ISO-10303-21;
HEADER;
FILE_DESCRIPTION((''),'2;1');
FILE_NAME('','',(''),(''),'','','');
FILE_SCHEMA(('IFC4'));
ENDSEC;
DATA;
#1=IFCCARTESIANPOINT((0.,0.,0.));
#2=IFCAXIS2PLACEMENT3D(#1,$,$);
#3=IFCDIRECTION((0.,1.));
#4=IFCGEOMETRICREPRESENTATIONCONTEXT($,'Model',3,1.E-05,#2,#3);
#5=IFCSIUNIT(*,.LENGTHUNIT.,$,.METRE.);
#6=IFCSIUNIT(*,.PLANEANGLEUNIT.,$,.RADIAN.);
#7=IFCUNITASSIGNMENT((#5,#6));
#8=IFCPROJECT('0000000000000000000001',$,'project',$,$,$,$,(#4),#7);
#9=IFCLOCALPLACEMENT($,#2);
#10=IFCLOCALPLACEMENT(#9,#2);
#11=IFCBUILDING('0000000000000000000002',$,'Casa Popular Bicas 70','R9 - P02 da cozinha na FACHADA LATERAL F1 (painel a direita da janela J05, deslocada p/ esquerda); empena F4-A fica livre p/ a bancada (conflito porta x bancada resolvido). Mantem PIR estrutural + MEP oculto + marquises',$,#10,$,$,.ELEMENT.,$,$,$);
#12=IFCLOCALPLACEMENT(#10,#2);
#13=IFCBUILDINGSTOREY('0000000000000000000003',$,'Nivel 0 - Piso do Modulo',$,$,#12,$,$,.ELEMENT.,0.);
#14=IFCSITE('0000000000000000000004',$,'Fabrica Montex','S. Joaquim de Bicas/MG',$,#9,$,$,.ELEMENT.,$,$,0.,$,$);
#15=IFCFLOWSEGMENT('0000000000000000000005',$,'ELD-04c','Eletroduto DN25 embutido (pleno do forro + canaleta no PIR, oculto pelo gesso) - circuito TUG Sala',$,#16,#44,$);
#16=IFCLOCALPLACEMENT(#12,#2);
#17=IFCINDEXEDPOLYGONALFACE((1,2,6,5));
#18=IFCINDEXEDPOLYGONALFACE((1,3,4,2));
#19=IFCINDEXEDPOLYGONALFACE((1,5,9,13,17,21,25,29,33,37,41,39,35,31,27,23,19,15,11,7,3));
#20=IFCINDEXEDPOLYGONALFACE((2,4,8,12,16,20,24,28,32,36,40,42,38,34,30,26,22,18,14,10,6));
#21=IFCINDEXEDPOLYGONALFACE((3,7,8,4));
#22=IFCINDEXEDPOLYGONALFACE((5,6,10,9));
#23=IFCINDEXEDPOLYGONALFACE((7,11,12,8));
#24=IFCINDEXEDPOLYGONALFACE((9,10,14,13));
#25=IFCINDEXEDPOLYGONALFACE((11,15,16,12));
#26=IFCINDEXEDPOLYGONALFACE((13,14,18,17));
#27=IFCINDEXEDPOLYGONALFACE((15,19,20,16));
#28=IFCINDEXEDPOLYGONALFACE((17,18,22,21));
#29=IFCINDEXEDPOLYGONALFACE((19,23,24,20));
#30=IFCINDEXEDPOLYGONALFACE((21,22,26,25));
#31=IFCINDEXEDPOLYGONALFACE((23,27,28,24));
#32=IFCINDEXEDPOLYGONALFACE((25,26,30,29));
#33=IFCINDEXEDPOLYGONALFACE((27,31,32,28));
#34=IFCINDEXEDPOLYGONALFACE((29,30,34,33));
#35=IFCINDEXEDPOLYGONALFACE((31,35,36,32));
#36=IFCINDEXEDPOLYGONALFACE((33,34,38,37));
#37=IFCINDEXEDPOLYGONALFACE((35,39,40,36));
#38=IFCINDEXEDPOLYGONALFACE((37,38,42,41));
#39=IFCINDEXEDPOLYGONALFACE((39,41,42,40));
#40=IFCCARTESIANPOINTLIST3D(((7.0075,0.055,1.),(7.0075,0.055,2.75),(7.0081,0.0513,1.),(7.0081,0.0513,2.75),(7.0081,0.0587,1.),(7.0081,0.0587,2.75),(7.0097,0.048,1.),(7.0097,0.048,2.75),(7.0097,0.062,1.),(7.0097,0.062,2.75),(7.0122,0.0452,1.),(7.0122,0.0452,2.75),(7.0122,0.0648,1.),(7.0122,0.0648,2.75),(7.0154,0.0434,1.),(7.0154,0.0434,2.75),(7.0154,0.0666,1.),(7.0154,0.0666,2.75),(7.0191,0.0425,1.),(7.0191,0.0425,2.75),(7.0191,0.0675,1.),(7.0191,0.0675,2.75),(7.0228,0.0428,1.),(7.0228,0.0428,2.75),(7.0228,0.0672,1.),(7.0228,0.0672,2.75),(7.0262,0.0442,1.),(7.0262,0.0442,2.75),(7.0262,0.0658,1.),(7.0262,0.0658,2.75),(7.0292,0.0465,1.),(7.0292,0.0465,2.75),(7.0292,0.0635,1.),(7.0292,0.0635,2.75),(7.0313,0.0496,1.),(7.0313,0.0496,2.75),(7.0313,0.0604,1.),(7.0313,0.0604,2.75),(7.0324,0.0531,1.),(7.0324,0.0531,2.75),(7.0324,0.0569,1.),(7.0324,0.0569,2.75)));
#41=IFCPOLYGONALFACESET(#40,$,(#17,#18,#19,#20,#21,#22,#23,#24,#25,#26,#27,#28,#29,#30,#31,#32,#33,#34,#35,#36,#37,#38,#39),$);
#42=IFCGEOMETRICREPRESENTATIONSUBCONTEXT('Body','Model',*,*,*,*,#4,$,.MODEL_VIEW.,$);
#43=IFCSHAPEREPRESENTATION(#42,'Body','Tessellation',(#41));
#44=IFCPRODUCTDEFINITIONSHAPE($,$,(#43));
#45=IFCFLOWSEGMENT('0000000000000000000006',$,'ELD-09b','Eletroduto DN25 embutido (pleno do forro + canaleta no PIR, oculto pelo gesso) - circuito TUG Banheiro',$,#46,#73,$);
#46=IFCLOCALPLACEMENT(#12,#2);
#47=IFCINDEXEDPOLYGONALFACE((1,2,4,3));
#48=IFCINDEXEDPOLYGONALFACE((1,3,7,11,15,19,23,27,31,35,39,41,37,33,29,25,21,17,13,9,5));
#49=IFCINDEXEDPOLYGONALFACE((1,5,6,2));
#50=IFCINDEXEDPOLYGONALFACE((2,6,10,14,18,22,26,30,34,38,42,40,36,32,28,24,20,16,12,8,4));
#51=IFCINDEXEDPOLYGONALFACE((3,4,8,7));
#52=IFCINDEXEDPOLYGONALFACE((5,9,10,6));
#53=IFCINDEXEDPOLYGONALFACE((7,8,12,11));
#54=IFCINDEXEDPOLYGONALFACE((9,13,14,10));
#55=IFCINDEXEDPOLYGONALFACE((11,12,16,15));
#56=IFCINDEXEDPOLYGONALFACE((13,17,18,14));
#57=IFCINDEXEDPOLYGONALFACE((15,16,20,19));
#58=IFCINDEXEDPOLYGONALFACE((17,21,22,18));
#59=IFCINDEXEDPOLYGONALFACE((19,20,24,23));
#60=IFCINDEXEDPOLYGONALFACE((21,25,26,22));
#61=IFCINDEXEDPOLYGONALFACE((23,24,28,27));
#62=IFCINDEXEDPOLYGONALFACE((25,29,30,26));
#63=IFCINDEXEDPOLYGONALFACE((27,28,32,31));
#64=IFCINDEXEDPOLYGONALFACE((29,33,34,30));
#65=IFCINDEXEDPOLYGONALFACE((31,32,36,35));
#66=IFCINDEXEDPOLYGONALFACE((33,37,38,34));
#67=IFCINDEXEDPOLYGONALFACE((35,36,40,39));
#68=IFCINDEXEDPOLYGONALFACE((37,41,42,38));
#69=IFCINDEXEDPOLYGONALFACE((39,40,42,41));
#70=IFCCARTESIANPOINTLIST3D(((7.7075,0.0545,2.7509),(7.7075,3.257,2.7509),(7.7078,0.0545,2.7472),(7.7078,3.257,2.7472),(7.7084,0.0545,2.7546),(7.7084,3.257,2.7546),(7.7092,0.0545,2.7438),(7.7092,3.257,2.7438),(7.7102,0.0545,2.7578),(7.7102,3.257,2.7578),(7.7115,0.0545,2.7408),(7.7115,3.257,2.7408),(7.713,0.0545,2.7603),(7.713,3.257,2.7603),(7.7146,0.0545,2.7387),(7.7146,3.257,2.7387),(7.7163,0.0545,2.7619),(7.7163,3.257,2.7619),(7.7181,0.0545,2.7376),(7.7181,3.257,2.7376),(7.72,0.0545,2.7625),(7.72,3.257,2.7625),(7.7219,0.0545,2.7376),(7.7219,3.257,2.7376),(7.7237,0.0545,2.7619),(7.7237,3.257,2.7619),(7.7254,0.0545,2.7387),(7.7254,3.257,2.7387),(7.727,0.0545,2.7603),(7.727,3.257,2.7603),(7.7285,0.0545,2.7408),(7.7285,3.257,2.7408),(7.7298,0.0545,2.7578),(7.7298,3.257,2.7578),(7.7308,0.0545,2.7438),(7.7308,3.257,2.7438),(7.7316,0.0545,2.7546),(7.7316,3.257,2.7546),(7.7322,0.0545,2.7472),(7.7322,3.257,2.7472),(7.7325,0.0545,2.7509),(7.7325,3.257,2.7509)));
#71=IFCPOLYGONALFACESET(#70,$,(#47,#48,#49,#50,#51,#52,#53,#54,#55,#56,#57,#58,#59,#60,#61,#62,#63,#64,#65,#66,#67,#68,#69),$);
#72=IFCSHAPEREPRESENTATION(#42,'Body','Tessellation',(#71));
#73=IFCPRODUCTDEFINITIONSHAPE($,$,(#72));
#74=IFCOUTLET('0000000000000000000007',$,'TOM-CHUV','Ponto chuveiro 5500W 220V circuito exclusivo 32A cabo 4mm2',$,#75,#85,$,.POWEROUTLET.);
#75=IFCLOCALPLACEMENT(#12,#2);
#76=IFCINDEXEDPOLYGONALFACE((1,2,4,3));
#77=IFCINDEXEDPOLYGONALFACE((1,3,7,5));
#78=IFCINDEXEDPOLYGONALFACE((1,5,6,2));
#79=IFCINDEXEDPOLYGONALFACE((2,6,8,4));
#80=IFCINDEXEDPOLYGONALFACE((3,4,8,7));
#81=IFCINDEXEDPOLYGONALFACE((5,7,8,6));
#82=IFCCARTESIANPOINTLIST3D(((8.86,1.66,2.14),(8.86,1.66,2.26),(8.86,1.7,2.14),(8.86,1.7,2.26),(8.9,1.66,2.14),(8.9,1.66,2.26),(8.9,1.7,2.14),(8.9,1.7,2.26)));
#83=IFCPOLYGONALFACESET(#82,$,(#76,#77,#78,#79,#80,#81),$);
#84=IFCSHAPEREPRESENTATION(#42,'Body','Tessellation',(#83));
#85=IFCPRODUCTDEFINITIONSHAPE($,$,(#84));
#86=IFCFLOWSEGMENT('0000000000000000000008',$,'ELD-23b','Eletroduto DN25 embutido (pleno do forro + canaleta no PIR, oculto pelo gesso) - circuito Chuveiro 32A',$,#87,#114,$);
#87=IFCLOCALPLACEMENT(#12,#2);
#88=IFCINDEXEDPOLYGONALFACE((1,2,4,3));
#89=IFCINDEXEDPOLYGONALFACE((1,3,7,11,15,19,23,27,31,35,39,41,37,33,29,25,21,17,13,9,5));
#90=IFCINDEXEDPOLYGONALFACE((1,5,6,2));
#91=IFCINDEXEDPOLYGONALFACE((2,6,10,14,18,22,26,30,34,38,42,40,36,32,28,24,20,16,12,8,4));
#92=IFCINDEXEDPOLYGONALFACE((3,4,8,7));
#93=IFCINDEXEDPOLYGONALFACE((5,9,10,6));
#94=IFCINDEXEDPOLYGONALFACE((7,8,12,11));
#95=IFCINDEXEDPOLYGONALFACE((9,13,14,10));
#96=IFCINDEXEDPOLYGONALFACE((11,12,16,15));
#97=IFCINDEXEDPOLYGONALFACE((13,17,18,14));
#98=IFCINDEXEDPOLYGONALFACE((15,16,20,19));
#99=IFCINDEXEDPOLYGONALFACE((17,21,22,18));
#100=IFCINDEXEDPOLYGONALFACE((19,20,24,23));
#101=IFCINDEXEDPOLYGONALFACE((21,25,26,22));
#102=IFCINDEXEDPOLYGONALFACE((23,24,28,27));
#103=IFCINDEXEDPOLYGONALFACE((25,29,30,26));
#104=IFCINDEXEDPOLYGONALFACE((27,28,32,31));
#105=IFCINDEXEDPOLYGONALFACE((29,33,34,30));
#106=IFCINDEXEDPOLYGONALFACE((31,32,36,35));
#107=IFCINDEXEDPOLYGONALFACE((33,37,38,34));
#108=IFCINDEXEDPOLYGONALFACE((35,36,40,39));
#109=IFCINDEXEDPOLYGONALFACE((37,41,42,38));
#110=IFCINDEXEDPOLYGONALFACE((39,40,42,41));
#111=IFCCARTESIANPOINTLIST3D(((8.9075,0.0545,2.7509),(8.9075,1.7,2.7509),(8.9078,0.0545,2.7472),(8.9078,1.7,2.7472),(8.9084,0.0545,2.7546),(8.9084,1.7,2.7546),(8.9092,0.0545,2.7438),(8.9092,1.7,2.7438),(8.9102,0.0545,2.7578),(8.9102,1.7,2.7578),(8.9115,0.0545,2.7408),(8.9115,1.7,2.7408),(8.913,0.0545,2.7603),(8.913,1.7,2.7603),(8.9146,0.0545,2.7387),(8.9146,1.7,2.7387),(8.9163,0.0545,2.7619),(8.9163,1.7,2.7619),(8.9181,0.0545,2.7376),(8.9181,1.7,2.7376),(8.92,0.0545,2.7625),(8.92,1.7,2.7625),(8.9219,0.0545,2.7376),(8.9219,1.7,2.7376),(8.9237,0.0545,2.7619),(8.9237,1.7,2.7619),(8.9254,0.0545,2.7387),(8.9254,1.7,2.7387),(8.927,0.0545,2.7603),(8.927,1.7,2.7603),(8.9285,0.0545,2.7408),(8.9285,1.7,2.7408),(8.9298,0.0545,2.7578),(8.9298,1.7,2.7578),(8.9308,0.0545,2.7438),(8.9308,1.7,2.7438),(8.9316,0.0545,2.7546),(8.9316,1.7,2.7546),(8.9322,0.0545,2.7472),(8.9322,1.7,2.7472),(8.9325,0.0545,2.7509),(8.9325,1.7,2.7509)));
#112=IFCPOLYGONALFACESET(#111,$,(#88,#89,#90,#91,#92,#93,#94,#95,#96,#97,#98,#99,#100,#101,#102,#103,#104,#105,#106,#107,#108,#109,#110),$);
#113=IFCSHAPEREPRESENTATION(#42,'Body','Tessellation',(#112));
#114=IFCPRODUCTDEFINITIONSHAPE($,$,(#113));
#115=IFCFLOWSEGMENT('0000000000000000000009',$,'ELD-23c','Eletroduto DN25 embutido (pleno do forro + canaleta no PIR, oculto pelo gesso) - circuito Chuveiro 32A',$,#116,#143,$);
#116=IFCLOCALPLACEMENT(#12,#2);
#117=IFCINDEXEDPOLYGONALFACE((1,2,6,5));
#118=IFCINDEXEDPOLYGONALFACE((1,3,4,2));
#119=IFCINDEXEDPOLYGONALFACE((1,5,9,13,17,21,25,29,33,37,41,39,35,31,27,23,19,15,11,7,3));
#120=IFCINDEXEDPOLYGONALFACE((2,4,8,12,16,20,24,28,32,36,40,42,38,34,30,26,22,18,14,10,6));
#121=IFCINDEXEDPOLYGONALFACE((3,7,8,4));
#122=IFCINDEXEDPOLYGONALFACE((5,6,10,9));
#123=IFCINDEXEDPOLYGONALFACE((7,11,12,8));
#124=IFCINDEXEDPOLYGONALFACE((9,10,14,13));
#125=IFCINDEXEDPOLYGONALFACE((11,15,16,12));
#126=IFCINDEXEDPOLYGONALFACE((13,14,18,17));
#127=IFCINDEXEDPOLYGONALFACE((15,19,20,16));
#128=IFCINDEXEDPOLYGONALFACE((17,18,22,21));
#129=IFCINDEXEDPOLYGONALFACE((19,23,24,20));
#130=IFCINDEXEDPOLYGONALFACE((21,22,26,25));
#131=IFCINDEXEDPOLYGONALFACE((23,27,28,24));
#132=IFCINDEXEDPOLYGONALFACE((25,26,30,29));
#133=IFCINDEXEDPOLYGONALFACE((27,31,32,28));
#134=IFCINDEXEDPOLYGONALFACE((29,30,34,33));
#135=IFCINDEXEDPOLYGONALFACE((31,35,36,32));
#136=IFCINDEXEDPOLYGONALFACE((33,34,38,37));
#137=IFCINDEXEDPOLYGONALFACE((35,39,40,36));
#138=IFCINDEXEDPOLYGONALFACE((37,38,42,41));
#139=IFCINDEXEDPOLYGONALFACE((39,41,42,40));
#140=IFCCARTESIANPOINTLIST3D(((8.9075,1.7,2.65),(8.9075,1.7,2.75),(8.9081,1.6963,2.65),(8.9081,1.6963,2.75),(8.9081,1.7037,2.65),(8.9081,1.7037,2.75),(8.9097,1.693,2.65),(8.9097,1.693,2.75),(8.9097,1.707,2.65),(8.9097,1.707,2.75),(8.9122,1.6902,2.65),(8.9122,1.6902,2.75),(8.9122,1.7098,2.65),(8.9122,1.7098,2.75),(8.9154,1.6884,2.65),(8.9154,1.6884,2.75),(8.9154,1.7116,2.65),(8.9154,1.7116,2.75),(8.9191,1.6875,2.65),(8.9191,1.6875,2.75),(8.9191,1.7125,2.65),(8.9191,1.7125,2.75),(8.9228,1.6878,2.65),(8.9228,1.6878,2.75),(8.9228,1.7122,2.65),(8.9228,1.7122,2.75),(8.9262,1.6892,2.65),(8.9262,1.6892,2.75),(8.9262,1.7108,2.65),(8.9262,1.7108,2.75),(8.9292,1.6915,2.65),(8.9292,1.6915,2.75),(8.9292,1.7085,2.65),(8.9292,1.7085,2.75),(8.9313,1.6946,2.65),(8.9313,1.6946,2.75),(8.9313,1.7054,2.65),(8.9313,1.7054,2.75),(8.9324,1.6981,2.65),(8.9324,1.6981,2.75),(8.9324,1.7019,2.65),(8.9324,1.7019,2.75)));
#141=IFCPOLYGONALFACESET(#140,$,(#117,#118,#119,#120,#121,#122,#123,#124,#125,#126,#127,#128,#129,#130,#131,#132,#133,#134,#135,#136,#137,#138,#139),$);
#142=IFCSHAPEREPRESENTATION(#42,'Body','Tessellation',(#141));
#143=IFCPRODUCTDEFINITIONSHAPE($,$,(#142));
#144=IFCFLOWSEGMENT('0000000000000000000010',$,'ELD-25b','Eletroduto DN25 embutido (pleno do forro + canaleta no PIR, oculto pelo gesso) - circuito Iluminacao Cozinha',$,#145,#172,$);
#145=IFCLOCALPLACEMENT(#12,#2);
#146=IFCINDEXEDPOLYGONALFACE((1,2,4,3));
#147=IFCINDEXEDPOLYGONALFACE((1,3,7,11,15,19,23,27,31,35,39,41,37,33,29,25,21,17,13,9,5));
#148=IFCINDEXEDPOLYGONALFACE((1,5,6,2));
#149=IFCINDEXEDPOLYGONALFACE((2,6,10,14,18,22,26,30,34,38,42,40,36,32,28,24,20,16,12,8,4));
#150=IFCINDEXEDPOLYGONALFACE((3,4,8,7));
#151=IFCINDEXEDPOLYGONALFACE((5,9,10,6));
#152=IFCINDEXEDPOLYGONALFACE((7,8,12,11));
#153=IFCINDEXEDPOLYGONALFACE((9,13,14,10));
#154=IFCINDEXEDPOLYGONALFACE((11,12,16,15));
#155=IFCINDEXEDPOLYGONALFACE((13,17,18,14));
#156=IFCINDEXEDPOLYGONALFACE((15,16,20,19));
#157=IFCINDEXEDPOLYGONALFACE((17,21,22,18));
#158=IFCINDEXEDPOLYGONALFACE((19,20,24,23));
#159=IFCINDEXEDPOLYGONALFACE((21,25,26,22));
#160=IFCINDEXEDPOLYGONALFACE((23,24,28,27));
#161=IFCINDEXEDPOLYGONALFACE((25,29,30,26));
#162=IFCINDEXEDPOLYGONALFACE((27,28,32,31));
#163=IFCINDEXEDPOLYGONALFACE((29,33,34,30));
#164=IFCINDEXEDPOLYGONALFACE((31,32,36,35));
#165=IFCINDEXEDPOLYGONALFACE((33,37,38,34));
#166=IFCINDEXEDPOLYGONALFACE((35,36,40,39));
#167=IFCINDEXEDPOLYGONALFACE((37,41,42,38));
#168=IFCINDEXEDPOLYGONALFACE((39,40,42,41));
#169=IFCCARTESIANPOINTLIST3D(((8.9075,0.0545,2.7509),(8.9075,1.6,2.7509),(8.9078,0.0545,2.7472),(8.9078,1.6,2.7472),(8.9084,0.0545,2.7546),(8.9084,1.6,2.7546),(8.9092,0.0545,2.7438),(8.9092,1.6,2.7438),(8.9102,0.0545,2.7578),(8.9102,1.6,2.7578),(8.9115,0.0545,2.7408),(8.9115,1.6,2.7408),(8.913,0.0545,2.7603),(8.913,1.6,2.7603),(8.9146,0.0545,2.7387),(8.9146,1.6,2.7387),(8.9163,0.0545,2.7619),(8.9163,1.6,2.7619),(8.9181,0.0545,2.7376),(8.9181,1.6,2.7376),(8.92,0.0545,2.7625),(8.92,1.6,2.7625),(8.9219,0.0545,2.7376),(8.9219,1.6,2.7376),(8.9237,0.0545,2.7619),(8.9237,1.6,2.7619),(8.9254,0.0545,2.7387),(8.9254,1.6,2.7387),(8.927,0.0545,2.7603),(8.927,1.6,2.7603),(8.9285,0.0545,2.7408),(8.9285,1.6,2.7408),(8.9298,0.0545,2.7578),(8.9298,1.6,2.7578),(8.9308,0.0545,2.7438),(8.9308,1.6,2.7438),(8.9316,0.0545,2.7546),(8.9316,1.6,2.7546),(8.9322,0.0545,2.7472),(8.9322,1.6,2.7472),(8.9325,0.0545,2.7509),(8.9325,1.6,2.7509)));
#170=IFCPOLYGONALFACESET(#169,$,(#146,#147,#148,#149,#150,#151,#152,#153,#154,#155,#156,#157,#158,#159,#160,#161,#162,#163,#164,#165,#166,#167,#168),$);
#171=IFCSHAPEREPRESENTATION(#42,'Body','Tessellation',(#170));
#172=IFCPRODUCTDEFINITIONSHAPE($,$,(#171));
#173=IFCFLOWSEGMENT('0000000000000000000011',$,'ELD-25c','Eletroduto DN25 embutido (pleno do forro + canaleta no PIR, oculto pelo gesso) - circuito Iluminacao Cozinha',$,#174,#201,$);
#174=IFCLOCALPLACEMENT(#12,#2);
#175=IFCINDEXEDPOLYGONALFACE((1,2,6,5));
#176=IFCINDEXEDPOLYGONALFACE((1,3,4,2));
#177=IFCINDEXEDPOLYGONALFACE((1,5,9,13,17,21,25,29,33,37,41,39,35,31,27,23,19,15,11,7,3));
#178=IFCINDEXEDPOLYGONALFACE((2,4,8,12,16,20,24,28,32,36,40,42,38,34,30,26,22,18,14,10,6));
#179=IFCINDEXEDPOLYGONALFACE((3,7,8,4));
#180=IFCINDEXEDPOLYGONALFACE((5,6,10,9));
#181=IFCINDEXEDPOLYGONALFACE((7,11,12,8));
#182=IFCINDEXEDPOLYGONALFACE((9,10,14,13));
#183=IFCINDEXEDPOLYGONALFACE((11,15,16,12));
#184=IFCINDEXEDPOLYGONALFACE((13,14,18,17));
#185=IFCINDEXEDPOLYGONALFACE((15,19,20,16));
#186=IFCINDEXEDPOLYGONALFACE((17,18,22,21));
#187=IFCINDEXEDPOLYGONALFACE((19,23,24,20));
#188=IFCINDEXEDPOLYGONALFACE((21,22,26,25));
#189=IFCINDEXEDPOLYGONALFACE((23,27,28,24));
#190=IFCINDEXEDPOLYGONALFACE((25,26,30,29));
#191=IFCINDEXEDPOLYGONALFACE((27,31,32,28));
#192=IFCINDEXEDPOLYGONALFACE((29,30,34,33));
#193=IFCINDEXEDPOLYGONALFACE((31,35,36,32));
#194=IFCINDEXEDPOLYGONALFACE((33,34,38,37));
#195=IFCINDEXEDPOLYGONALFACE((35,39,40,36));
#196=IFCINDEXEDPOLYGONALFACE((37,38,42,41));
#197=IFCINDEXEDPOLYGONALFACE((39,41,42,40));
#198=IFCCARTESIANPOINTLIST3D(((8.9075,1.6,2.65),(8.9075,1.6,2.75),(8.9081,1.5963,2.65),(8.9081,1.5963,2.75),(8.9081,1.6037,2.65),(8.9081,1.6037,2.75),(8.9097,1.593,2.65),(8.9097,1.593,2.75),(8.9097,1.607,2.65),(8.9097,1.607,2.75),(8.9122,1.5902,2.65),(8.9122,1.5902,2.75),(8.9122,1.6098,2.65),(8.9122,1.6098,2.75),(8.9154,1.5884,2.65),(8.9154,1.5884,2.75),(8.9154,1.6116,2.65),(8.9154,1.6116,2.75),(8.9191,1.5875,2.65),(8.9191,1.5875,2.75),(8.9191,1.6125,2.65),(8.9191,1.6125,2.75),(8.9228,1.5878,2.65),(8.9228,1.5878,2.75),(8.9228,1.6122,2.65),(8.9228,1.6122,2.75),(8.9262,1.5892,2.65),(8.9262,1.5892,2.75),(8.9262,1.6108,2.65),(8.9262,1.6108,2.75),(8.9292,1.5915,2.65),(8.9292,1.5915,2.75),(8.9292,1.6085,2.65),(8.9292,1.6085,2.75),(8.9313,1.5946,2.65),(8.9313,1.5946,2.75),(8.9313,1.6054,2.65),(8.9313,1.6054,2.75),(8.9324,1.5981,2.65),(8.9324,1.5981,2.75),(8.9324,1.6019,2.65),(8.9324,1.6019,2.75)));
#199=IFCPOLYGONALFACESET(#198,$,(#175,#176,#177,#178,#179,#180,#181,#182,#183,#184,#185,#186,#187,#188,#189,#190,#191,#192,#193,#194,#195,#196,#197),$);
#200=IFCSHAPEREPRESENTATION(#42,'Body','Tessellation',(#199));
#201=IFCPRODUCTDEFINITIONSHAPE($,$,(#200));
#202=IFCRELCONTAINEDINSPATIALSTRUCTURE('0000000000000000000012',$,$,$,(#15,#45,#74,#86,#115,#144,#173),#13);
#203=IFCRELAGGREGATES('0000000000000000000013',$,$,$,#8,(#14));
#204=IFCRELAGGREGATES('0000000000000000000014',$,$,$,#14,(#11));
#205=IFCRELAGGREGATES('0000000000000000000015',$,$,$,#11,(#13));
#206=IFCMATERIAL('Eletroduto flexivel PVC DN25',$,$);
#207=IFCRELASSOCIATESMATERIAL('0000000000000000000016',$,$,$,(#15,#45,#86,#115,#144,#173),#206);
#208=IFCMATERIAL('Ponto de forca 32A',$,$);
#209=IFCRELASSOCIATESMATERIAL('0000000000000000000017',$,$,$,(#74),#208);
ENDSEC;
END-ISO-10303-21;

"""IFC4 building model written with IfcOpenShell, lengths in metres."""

from ifc_helpers import new_model, si_unit, direction, frame, frame_2d, origin, origin_2d, place, context, subcontext, project, spatial, rectangle, circle, extrude, material, element, save


model = new_model("IFC4")

# Units and contexts
model_context = context("Model", 3, precision=1e-05, world=origin(), true_north=direction((0.0, 1.0)))
body_context = subcontext(model_context, "Body", "Model", "MODEL_VIEW")
ifc_project = project(units=[si_unit("LENGTHUNIT", "METRE"), si_unit("PLANEANGLEUNIT", "RADIAN")], contexts=[model_context])

# Site, building, storey
site_placement = place(None, origin())
site = spatial("IfcSite", under=ifc_project, at=site_placement, Name="Fabrica Montex", Description="S. Joaquim de Bicas/MG", CompositionType="ELEMENT", RefElevation=0.0)
building_placement = place(site_placement, origin())
building = spatial("IfcBuilding", under=site, at=building_placement, Name="Casa Popular Bicas 70", Description="R9 - P02 da cozinha na FACHADA LATERAL F1 (painel a direita da janela J05, deslocada p/ esquerda); empena F4-A fica livre p/ a bancada (conflito porta x bancada resolvido). Mantem PIR estrutural + MEP oculto + marquises", CompositionType="ELEMENT")
storey_placement = place(building_placement, origin())
storey = spatial("IfcBuildingStorey", under=building, at=storey_placement, Name="Nivel 0 - Piso do Modulo", CompositionType="ELEMENT", Elevation=0.0)

# Shared definitions
ifc_material_1 = material(Name="Eletroduto flexivel PVC DN25")

# Flow segments
flow_segment_1_placement = place(None, frame((7.02, 0.055, 2.75), z_axis=(0.0, 0.0, -1.0), x_axis=(-1.0, 0.0, 0.0)))
element("IfcFlowSegment", 1, at=flow_segment_1_placement, inside=storey, material=ifc_material_1, Name="ELD-04c", Description="Eletroduto DN25 embutido (pleno do forro + canaleta no PIR, oculto pelo gesso) - circuito TUG Sala", context=body_context, shape_type="SweptSolid", body=[
    extrude(circle(Radius=0.0125, at=origin_2d()), origin(), (0.0, 0.0, 1.0), 1.75),
])
flow_segment_2_placement = place(None, frame((7.72, 0.0545, 2.75), z_axis=(0.0, 1.0, 0.0), x_axis=(0.0, 0.0, 1.0)))
element("IfcFlowSegment", 2, at=flow_segment_2_placement, inside=storey, material=ifc_material_1, Name="ELD-09b", Description="Eletroduto DN25 embutido (pleno do forro + canaleta no PIR, oculto pelo gesso) - circuito TUG Banheiro", context=body_context, shape_type="SweptSolid", body=[
    extrude(circle(Radius=0.0125, at=origin_2d()), origin(), (0.0, 0.0, 1.0), 3.2025),
])

# Outlet
ifc_material_2 = material(Name="Ponto de forca 32A")
outlet_1_placement = place(None, frame((8.9, 1.7, 2.14), z_axis=(0.0, 0.0, 1.0), x_axis=(-1.0, 0.0, 0.0)))
element("IfcOutlet", 3, at=outlet_1_placement, inside=storey, material=ifc_material_2, Name="TOM-CHUV", Description="Ponto chuveiro 5500W 220V circuito exclusivo 32A cabo 4mm2", PredefinedType="POWEROUTLET", context=body_context, shape_type="SweptSolid", body=[
    extrude(rectangle(XDim=0.04, YDim=0.04, at=frame_2d((0.02, 0.02))), origin(), (0.0, 0.0, 1.0), 0.12),
])

# Flow segments
flow_segment_3_placement = place(None, frame((8.92, 0.0545, 2.75), z_axis=(0.0, 1.0, 0.0), x_axis=(0.0, 0.0, 1.0)))
element("IfcFlowSegment", 4, at=flow_segment_3_placement, inside=storey, material=ifc_material_1, Name="ELD-23b", Description="Eletroduto DN25 embutido (pleno do forro + canaleta no PIR, oculto pelo gesso) - circuito Chuveiro 32A", context=body_context, shape_type="SweptSolid", body=[
    extrude(circle(Radius=0.0125, at=origin_2d()), origin(), (0.0, 0.0, 1.0), 1.6455),
])
flow_segment_4_placement = place(None, frame((8.92, 1.7, 2.75), z_axis=(0.0, 0.0, -1.0), x_axis=(-1.0, 0.0, 0.0)))
element("IfcFlowSegment", 5, at=flow_segment_4_placement, inside=storey, material=ifc_material_1, Name="ELD-23c", Description="Eletroduto DN25 embutido (pleno do forro + canaleta no PIR, oculto pelo gesso) - circuito Chuveiro 32A", context=body_context, shape_type="SweptSolid", body=[
    extrude(circle(Radius=0.0125, at=origin_2d()), origin(), (0.0, 0.0, 1.0), 0.1),
])
flow_segment_5_placement = place(None, frame((8.92, 0.0545, 2.75), z_axis=(0.0, 1.0, 0.0), x_axis=(0.0, 0.0, 1.0)))
element("IfcFlowSegment", 6, at=flow_segment_5_placement, inside=storey, material=ifc_material_1, Name="ELD-25b", Description="Eletroduto DN25 embutido (pleno do forro + canaleta no PIR, oculto pelo gesso) - circuito Iluminacao Cozinha", context=body_context, shape_type="SweptSolid", body=[
    extrude(circle(Radius=0.0125, at=origin_2d()), origin(), (0.0, 0.0, 1.0), 1.5455),
])
flow_segment_6_placement = place(None, frame((8.92, 1.6, 2.75), z_axis=(0.0, 0.0, -1.0), x_axis=(-1.0, 0.0, 0.0)))
element("IfcFlowSegment", 7, at=flow_segment_6_placement, inside=storey, material=ifc_material_1, Name="ELD-25c", Description="Eletroduto DN25 embutido (pleno do forro + canaleta no PIR, oculto pelo gesso) - circuito Iluminacao Cozinha", context=body_context, shape_type="SweptSolid", body=[
    extrude(circle(Radius=0.0125, at=origin_2d()), origin(), (0.0, 0.0, 1.0), 0.1),
])

save(model, "model.ifc")
